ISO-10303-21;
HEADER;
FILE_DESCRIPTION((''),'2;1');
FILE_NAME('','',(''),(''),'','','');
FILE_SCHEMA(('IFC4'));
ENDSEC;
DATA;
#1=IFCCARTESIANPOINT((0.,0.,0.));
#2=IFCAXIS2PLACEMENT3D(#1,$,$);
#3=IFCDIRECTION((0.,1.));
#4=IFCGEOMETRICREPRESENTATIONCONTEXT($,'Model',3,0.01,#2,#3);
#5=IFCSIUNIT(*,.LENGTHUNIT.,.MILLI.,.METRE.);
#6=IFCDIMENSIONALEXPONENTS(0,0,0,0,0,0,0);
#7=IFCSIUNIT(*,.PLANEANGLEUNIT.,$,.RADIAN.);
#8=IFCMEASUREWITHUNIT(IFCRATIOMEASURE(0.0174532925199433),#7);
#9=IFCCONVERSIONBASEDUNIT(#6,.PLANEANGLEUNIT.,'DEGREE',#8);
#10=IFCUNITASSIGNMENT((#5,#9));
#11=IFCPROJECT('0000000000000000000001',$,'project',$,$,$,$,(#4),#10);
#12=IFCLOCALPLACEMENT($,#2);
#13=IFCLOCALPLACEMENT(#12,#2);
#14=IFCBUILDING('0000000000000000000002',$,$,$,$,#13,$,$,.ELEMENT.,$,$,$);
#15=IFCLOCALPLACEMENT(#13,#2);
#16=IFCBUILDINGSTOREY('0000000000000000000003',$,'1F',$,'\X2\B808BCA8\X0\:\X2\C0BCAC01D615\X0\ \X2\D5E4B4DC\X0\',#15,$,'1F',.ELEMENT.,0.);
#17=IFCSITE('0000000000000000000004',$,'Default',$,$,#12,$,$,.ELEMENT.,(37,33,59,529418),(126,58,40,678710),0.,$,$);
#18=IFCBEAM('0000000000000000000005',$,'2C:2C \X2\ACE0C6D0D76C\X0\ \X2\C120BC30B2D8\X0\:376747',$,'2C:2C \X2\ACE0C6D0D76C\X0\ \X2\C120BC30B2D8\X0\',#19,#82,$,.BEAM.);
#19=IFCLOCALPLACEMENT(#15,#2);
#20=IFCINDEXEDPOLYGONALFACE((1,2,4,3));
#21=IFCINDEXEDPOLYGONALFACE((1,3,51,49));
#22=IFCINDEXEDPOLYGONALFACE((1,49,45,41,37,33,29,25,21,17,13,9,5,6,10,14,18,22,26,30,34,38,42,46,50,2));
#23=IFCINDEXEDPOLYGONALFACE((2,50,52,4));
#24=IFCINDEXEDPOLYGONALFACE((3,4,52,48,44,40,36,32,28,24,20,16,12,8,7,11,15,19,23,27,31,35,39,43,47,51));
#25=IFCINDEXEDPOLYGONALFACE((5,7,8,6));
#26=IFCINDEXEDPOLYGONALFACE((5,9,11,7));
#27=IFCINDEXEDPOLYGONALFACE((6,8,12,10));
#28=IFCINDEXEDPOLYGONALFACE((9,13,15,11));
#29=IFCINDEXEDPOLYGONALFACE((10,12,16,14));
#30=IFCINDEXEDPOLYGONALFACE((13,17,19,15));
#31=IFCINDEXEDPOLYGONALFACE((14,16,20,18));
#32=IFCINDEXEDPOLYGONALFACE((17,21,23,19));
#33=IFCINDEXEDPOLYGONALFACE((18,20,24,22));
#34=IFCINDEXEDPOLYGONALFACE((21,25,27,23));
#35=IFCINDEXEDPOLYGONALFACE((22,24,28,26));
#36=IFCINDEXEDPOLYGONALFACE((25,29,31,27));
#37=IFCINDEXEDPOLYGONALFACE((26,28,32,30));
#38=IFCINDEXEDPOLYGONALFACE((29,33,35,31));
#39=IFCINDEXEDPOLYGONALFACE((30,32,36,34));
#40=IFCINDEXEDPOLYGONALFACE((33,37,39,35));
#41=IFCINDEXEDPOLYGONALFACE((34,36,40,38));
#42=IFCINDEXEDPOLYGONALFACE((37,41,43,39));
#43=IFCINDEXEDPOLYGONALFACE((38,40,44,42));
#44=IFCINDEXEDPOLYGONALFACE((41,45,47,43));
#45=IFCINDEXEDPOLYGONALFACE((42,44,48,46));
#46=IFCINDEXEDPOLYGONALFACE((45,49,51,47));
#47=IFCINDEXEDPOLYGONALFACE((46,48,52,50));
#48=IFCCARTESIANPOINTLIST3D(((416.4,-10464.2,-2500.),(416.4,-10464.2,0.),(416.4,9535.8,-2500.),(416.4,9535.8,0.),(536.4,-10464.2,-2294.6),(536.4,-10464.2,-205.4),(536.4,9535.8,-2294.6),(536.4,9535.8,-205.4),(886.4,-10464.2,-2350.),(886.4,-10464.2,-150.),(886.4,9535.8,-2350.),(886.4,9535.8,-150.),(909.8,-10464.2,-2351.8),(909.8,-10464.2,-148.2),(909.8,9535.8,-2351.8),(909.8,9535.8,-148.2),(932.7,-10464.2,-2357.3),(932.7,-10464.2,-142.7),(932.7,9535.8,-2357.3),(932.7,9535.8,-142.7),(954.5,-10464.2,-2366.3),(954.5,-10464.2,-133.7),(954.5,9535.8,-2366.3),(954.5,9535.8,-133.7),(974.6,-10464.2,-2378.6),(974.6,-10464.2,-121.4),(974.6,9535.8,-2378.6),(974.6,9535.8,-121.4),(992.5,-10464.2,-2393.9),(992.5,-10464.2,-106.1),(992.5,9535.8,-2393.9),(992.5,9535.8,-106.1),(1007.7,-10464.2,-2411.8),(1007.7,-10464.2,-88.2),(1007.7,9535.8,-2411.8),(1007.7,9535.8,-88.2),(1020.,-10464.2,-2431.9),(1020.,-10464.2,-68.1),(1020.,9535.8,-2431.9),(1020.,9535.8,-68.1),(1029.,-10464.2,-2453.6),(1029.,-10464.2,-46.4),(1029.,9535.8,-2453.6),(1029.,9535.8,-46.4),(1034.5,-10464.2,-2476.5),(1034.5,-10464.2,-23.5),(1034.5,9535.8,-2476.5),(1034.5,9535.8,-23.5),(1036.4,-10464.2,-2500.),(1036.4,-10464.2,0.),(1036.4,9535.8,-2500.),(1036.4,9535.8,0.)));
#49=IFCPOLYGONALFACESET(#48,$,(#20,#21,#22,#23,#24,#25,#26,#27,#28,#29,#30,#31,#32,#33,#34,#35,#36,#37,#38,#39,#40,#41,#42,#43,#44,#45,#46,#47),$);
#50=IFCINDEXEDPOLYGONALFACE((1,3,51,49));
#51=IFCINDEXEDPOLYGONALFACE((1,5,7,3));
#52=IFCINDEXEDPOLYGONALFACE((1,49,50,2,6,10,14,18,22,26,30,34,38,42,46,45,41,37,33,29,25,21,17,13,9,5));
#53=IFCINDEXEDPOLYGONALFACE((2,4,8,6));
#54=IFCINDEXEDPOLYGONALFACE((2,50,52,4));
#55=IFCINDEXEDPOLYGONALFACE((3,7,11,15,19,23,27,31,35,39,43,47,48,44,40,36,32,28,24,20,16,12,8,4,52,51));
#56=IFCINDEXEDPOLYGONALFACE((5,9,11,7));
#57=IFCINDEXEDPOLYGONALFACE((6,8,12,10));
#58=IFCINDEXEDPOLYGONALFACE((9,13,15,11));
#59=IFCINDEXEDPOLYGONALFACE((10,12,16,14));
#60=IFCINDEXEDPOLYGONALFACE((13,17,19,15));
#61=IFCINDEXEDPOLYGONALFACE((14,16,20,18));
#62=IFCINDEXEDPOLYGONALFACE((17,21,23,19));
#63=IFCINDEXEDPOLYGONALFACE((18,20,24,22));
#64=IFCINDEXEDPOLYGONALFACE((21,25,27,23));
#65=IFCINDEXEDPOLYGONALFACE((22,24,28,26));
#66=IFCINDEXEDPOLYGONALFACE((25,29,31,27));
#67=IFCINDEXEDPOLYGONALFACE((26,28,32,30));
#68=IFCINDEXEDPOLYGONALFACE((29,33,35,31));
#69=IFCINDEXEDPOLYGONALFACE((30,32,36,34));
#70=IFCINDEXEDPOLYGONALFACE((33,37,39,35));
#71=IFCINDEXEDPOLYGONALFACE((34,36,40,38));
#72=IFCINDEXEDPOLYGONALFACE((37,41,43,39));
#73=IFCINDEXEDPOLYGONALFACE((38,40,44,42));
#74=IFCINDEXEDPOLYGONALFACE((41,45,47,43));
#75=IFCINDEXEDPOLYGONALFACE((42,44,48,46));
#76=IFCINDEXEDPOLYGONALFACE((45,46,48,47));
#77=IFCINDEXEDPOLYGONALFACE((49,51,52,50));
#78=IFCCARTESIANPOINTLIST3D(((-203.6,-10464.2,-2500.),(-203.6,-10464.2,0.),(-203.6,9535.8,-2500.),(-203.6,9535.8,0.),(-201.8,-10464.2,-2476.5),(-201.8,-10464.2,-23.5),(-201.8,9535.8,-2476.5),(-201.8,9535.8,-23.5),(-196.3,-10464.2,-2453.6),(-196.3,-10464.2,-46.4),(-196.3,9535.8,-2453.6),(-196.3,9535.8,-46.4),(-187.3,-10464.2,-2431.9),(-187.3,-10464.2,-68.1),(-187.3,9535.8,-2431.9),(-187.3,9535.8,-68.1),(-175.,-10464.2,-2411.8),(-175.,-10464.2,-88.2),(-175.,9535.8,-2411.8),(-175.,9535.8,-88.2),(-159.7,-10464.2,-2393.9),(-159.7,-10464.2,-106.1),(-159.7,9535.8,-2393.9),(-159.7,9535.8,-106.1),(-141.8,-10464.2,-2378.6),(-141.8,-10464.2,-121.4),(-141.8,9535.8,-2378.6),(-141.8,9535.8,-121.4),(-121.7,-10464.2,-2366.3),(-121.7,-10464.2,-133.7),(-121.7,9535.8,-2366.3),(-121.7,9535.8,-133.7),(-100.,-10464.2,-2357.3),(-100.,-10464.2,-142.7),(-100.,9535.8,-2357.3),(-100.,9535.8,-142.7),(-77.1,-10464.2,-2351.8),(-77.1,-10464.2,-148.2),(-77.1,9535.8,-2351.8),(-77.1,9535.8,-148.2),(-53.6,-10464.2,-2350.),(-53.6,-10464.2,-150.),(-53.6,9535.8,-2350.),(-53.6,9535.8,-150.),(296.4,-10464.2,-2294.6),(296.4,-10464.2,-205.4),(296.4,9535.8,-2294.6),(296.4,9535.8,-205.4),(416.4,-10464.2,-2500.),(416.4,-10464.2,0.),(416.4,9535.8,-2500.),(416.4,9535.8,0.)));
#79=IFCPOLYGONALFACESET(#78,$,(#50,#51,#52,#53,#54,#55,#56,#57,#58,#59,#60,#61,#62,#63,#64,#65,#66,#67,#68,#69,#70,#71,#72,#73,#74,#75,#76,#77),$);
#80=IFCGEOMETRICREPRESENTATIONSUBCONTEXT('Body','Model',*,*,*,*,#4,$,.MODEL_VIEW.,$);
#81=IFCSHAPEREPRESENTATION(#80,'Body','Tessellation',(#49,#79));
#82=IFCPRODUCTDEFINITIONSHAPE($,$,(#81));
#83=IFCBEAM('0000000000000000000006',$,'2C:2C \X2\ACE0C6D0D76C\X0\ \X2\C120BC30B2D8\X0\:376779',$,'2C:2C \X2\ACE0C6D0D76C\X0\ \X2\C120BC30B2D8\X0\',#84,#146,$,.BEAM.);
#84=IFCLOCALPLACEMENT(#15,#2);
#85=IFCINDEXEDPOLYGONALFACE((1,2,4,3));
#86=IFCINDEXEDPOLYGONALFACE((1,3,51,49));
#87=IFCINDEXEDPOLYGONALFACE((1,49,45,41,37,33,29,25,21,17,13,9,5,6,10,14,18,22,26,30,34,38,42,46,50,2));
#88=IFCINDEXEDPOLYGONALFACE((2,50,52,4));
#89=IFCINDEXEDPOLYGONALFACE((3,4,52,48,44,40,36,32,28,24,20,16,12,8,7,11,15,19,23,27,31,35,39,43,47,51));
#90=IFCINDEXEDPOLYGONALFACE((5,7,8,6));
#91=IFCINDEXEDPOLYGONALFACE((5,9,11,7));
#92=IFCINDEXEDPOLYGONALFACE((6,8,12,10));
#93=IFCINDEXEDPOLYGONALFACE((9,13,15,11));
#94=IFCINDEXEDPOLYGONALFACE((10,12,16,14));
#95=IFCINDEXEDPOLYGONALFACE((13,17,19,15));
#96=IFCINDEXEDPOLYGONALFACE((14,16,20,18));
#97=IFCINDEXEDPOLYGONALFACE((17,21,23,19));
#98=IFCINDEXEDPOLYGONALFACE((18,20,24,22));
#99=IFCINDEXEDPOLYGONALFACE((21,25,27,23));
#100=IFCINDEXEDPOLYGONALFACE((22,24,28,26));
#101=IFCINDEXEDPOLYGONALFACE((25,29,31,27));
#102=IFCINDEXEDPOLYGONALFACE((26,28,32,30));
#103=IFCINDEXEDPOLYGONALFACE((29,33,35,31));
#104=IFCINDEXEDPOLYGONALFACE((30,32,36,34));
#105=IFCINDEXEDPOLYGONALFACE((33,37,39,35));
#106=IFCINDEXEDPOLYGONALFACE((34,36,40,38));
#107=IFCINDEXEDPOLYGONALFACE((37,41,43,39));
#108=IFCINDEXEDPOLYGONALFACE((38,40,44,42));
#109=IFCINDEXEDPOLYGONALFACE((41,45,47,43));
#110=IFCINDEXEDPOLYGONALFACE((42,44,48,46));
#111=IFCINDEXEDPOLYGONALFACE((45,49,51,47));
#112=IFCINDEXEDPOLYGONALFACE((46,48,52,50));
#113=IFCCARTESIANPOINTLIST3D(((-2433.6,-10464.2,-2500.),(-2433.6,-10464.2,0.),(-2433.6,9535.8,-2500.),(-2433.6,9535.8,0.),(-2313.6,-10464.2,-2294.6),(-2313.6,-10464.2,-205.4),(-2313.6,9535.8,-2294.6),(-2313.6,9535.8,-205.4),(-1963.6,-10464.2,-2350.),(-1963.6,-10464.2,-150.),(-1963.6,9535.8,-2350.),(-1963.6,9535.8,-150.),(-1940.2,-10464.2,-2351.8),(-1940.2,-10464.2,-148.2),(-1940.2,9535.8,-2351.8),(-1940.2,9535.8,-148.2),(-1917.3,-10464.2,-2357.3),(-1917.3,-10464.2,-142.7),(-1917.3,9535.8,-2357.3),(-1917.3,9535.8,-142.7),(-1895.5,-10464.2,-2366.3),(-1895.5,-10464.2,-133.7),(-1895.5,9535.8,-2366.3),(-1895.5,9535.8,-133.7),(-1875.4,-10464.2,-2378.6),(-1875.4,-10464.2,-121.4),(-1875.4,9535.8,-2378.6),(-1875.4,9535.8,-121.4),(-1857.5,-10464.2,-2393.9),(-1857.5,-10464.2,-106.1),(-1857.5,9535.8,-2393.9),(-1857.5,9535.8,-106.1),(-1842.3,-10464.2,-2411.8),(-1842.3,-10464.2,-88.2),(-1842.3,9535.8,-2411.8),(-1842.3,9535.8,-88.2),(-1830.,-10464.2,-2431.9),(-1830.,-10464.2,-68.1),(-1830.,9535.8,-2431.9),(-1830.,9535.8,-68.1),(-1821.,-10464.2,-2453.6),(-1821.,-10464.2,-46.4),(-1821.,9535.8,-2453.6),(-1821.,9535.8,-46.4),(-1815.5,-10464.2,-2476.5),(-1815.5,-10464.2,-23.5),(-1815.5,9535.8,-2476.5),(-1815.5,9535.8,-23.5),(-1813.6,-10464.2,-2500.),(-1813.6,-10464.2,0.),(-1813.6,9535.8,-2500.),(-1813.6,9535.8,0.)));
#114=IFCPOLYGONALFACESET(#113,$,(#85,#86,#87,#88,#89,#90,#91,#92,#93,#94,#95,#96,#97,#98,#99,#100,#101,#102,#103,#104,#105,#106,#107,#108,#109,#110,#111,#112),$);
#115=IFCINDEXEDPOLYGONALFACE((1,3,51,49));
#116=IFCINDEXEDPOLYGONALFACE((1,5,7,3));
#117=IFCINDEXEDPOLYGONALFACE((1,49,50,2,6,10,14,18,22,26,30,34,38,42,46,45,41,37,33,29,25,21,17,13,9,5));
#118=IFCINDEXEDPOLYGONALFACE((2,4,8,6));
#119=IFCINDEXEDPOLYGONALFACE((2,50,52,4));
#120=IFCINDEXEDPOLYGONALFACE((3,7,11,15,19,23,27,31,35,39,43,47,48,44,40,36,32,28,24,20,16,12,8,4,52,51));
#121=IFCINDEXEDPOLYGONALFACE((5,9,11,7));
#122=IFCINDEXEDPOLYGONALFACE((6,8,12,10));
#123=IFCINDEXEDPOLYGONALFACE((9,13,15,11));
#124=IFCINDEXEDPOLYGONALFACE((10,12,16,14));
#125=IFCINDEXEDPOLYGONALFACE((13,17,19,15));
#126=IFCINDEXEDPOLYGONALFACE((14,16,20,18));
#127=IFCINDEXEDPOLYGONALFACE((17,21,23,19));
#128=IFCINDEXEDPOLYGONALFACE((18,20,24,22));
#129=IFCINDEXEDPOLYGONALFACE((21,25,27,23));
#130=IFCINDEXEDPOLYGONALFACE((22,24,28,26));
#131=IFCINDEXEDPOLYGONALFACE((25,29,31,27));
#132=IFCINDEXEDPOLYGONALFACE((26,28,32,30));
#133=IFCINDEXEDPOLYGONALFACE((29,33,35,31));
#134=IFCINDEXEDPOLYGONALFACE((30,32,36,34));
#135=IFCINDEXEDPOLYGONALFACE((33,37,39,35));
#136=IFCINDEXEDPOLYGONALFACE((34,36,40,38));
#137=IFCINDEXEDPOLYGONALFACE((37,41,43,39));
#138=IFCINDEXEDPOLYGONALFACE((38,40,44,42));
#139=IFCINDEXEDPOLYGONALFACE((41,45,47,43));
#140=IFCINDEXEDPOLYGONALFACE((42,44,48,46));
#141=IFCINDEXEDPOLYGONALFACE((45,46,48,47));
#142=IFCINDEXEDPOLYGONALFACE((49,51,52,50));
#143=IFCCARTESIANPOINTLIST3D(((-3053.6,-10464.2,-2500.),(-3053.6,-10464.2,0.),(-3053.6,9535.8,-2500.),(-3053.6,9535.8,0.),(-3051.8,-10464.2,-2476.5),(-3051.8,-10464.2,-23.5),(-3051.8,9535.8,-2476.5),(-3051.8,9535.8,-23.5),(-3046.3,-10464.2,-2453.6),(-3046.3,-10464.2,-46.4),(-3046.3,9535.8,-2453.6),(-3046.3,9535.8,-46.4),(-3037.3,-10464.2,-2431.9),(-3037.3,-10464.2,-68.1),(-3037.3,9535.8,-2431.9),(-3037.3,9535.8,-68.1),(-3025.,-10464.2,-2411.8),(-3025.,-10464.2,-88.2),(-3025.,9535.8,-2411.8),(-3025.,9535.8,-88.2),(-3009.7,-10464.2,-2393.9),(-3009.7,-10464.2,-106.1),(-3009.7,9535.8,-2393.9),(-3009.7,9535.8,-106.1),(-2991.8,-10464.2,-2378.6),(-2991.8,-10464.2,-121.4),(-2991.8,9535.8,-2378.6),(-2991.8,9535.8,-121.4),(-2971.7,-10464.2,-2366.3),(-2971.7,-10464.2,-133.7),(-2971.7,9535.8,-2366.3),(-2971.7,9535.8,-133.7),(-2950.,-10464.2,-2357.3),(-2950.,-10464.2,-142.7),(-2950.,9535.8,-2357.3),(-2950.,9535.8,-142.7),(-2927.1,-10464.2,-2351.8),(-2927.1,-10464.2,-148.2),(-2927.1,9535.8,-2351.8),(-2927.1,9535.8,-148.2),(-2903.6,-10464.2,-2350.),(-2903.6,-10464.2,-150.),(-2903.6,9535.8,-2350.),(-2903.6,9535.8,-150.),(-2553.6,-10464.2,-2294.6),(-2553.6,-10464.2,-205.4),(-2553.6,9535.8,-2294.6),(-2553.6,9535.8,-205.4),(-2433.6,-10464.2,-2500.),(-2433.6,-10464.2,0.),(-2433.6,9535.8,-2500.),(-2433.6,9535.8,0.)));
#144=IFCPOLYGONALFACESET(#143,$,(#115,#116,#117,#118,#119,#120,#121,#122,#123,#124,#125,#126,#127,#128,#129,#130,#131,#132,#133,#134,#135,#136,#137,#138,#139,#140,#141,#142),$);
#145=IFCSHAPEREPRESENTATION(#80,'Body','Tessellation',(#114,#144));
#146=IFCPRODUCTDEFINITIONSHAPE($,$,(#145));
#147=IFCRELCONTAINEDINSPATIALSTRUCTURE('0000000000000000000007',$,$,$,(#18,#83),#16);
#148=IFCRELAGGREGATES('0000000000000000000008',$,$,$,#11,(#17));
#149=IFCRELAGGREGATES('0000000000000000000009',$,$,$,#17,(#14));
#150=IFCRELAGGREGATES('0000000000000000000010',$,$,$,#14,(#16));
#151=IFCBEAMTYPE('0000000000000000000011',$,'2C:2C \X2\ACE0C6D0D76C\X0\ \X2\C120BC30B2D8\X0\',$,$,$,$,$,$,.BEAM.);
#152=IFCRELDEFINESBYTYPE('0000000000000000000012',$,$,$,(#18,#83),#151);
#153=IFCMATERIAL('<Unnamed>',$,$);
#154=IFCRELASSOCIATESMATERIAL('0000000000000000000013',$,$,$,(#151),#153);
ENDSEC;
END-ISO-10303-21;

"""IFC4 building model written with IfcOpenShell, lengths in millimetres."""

from ifc_helpers import new_model, entity, si_unit, converted_unit, direction, frame, origin, place, context, subcontext, project, spatial, indexed_curve, outline, extrude, source, transform, mapped, material, type_object, type_shapes, element, save


model = new_model("IFC4")

# Units and contexts
model_context = context("Model", 3, precision=0.01, world=origin(), true_north=direction((0.0, 1.0)))
body_context = subcontext(model_context, "Body", "Model", "MODEL_VIEW")
ifc_project = project(units=[si_unit("LENGTHUNIT", "METRE", prefix="MILLI"), converted_unit("PLANEANGLEUNIT", "DEGREE", entity("IfcRatioMeasure", 0.0174532925199433), si_unit("PLANEANGLEUNIT", "RADIAN"), dimensions=[0, 0, 0, 0, 0, 0, 0])], contexts=[model_context])

# Site, building, storey
site_placement = place(None, origin())
site = spatial("IfcSite", under=ifc_project, at=site_placement, Name="Default", CompositionType="ELEMENT", RefLatitude=(37, 33, 59, 529418), RefLongitude=(126, 58, 40, 678710), RefElevation=0.0)
building_placement = place(site_placement, origin())
building = spatial("IfcBuilding", under=site, at=building_placement, CompositionType="ELEMENT")
storey_placement = place(building_placement, origin())
storey = spatial("IfcBuildingStorey", under=building, at=storey_placement, Name="1F", ObjectType="레벨:삼각형 헤드", LongName="1F", CompositionType="ELEMENT", Elevation=0.0)

# Beams
ifc_material = material(Name="<Unnamed>")
beam_type_1 = type_object("IfcBeamType", Name="2C:2C 고원희 선배님", PredefinedType="BEAM", material=ifc_material)
shared_shape_1 = source(origin(), body_context, "Body", "SweptSolid", [
    extrude(outline(indexed_curve([(-1250.0, -302.5), (1250.0, -302.5), (1250.0, 317.5), (1226.5, 315.7), (1203.6, 310.2), (1181.9, 301.2), (1161.8, 288.9), (1143.9, 273.6), (1128.6, 255.7), (1116.3, 235.6), (1107.3, 213.9), (1101.8, 191.0), (1100.0, 167.5), (1044.6, -182.5), (-1044.6, -182.5), (-1100.0, 167.5), (-1101.8, 191.0), (-1107.3, 213.9), (-1116.3, 235.6), (-1128.6, 255.7), (-1143.9, 273.6), (-1161.8, 288.9), (-1181.9, 301.2), (-1203.6, 310.2), (-1226.5, 315.7), (-1250.0, 317.5), (-1250.0, -302.5)], self_intersect=False)), frame((-10000.0, 302.5, 0.0), z_axis=(1.0, 0.0, 0.0), x_axis=(0.0, 0.0, -1.0)), (0.0, 0.0, 1.0), 20000.0),
    extrude(outline(indexed_curve([(-317.5, -1250.0), (302.5, -1250.0), (302.5, 1250.0), (-317.5, 1250.0), (-315.7, 1226.5), (-310.2, 1203.6), (-301.2, 1181.9), (-288.9, 1161.8), (-273.6, 1143.9), (-255.7, 1128.6), (-235.6, 1116.3), (-213.9, 1107.3), (-191.0, 1101.8), (-167.5, 1100.0), (182.5, 1044.6), (182.5, -1044.6), (-167.5, -1100.0), (-191.0, -1101.8), (-213.9, -1107.3), (-235.6, -1116.3), (-255.7, -1128.6), (-273.6, -1143.9), (-288.9, -1161.8), (-301.2, -1181.9), (-310.2, -1203.6), (-315.7, -1226.5), (-317.5, -1250.0)], self_intersect=False)), frame((-10000.0, -302.5, 0.0), z_axis=(1.0, 0.0, 0.0), x_axis=(0.0, 1.0, 0.0)), (0.0, 0.0, 1.0), 20000.0),
])
type_shapes(beam_type_1, [shared_shape_1])
for number, where, z_axis, x_axis, name in (
    (1, (416.4, -464.2, -1250.0), (0.0, 0.0, 1.0), (0.0, -1.0, 0.0), "2C:2C 고원희 선배님:376747"),
    (2, (-2433.6, -464.2, -1250.0), (0.0, 0.0, 1.0), (0.0, -1.0, 0.0), "2C:2C 고원희 선배님:376779"),
):
    element("IfcBeam", number, at=place(storey_placement, frame(where, z_axis=z_axis, x_axis=x_axis)), inside=storey, type_object=beam_type_1, Name=name, ObjectType="2C:2C 고원희 선배님", PredefinedType="BEAM", context=body_context, shape_type="MappedRepresentation", body=[
        mapped(shared_shape_1, transform((0.0, 0.0, 0.0), scale=1.0)),
    ])

save(model, "model.ifc")
